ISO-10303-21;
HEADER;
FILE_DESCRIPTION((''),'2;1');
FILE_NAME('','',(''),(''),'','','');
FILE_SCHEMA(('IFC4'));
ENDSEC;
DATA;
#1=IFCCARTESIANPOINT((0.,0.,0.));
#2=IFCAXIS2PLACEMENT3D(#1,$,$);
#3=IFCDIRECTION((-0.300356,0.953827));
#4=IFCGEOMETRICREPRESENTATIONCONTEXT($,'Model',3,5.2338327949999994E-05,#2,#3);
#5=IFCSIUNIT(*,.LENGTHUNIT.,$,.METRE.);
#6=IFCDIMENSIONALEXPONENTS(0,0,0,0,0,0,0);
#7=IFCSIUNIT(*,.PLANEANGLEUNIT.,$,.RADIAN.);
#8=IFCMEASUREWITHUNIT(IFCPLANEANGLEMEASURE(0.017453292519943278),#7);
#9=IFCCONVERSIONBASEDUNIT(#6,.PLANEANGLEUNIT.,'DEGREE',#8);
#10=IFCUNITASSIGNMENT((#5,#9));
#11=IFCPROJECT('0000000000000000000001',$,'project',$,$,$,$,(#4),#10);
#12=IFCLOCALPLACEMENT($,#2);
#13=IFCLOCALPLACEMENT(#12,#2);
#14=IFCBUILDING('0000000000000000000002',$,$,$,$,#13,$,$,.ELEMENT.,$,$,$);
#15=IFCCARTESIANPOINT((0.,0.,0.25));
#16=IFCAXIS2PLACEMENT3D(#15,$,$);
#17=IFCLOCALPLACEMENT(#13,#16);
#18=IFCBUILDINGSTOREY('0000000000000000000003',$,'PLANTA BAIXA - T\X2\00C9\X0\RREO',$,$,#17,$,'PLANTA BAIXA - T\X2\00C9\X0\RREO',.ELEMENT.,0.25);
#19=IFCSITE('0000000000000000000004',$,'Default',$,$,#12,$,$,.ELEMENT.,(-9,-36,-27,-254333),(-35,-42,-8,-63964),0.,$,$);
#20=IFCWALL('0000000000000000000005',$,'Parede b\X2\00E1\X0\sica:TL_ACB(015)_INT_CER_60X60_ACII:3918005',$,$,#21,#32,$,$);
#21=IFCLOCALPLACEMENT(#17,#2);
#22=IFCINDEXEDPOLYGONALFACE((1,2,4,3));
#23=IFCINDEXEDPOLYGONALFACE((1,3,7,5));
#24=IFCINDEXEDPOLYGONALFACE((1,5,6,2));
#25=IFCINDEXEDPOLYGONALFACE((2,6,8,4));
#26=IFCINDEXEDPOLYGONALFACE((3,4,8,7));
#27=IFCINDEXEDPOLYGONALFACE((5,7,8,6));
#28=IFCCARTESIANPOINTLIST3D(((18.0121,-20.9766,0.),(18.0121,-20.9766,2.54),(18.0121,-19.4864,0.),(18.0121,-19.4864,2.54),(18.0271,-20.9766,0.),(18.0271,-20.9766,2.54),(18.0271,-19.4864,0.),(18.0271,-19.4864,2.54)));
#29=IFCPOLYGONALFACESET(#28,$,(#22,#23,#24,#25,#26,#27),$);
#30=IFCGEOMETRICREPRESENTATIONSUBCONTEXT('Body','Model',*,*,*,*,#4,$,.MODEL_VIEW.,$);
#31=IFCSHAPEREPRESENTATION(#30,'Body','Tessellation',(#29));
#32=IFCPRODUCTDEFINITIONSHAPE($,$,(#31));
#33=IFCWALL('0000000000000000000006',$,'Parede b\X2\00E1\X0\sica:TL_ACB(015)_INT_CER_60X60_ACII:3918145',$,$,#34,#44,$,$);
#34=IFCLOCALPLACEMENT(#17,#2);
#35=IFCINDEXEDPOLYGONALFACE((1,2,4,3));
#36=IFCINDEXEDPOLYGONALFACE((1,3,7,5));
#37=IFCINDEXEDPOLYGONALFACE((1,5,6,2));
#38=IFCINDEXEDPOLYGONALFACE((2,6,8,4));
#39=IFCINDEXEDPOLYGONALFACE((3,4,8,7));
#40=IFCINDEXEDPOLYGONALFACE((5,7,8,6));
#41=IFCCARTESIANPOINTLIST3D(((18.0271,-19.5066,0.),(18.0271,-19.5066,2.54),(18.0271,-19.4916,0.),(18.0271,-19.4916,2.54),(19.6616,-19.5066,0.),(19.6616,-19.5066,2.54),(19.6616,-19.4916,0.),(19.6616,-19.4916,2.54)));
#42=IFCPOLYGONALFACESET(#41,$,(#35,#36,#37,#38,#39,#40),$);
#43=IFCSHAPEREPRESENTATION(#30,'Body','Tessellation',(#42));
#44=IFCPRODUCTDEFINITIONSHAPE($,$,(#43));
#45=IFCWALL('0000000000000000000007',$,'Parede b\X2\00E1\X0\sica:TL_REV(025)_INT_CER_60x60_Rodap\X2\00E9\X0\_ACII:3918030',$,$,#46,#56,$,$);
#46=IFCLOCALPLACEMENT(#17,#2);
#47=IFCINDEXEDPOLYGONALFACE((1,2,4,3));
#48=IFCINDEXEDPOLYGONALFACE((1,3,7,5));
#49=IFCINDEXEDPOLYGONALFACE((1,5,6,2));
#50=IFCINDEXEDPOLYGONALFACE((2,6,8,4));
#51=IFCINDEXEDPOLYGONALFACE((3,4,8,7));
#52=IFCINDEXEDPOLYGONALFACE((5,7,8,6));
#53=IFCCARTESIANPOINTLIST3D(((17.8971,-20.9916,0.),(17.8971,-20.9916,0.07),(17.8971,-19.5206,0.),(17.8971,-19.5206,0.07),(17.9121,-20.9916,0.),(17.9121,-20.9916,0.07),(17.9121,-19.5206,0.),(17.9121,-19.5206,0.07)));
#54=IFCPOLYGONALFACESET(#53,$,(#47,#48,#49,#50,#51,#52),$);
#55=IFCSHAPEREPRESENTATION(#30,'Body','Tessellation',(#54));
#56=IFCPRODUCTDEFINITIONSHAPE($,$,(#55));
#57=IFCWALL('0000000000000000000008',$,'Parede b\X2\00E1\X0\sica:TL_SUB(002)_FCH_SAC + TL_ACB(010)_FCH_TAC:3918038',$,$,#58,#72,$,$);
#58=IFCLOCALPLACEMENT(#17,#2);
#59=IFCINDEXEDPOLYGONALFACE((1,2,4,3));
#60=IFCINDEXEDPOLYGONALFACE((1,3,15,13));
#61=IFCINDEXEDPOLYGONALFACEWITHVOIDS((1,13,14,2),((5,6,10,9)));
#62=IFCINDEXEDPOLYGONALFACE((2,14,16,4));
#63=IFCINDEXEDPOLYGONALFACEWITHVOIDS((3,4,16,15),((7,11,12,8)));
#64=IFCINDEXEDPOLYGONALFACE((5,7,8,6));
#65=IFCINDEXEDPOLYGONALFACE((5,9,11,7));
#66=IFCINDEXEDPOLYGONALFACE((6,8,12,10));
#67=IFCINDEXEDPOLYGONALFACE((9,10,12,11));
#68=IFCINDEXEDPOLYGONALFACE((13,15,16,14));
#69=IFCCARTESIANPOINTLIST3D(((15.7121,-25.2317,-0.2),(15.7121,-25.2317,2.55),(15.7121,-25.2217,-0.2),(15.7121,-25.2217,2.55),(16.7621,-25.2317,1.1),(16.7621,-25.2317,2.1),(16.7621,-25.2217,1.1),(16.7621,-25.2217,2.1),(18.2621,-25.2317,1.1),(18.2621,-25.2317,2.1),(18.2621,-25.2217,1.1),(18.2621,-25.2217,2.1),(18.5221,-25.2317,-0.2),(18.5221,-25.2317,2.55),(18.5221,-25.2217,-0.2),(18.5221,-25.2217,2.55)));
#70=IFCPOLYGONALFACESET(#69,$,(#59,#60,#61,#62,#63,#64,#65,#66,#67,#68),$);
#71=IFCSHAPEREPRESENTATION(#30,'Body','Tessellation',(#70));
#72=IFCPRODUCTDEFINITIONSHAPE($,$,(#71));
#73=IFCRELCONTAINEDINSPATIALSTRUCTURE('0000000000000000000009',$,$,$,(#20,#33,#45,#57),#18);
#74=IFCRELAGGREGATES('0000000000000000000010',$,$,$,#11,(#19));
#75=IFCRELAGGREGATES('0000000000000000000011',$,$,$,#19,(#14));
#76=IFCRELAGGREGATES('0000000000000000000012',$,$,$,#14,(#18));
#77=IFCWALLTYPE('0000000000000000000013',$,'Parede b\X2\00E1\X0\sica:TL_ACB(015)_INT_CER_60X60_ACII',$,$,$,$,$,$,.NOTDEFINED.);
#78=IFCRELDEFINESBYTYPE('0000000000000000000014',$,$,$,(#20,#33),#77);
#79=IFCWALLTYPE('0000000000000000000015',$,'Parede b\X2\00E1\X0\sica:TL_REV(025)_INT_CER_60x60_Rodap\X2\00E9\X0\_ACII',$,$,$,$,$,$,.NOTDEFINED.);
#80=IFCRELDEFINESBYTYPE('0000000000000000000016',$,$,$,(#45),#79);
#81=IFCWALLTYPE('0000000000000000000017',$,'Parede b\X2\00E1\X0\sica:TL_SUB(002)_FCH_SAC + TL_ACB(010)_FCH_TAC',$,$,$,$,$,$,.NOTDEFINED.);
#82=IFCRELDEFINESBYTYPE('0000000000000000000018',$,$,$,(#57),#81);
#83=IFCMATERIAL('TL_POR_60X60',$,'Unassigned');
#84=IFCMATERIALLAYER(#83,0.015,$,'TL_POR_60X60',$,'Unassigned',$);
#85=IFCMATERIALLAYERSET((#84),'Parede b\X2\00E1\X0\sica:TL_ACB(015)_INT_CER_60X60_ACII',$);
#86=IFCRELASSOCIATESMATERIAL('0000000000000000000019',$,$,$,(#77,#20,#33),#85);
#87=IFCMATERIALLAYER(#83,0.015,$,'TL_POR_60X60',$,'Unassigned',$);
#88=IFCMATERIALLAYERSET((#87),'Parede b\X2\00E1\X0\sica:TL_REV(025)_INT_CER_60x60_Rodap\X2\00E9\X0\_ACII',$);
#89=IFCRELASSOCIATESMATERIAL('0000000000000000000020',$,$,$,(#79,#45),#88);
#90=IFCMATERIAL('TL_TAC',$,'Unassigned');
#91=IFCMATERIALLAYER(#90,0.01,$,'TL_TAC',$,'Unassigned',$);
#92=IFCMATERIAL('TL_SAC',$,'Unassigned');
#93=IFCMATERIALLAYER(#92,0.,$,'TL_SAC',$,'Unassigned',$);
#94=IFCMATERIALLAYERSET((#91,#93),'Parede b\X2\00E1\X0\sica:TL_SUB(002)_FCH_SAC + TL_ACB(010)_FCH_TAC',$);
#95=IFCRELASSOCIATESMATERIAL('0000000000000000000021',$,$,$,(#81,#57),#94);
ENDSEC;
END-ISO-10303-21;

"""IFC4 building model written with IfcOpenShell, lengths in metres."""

from ifc_helpers import new_model, entity, si_unit, converted_unit, direction, frame, frame_2d, origin, place, context, subcontext, project, spatial, rectangle, extrude, material, layer, layer_set, layer_usage, type_object, element, save


model = new_model("IFC4")

# Units and contexts
model_context = context("Model", 3, precision=5.2338327949999994e-05, world=origin(), true_north=direction((-0.300356, 0.953827)))
body_context = subcontext(model_context, "Body", "Model", "MODEL_VIEW")
ifc_project = project(units=[si_unit("LENGTHUNIT", "METRE"), converted_unit("PLANEANGLEUNIT", "DEGREE", entity("IfcPlaneAngleMeasure", 0.017453292519943278), si_unit("PLANEANGLEUNIT", "RADIAN"), dimensions=[0, 0, 0, 0, 0, 0, 0])], contexts=[model_context])

# Site, building, storey
site_placement = place(None, origin())
site = spatial("IfcSite", under=ifc_project, at=site_placement, Name="Default", CompositionType="ELEMENT", RefLatitude=(-9, -36, -27, -254333), RefLongitude=(-35, -42, -8, -63964), RefElevation=0.0)
building_placement = place(site_placement, origin())
building = spatial("IfcBuilding", under=site, at=building_placement, CompositionType="ELEMENT")
storey_placement = place(building_placement, frame((0.0, 0.0, 0.25)))
storey = spatial("IfcBuildingStorey", under=building, at=storey_placement, Name="PLANTA BAIXA - TÉRREO", LongName="PLANTA BAIXA - TÉRREO", CompositionType="ELEMENT", Elevation=0.25)

# Shared definitions
ifc_material_1 = material(Name="TL_SAC", Category="Unassigned")

# Walls
ifc_material_2 = material(Name="TL_POR_60X60", Category="Unassigned")
ifc_layer_1 = layer(ifc_material_2, 0.015, Name="TL_POR_60X60", Category="Unassigned")
ifc_layer_set_1 = layer_set([ifc_layer_1], Name="Parede básica:TL_ACB(015)_INT_CER_60X60_ACII")
ifc_layer_usage_1 = layer_usage(ifc_layer_set_1, "AXIS2", "NEGATIVE", 0.0075)
wall_type_1 = type_object("IfcWallType", Name="Parede básica:TL_ACB(015)_INT_CER_60X60_ACII", PredefinedType="NOTDEFINED", material=ifc_layer_set_1)
wall_1_placement = place(storey_placement, frame((18.0196, -19.4864, 0.0), z_axis=(0.0, 0.0, 1.0), x_axis=(0.0, -1.0, 0.0)))
element("IfcWall", 1, at=wall_1_placement, inside=storey, type_object=wall_type_1, material=ifc_layer_usage_1, Name="Parede básica:TL_ACB(015)_INT_CER_60X60_ACII:3918005", context=body_context, shape_type="SweptSolid", body=[
    extrude(rectangle(XDim=1.4902, YDim=0.015, at=frame_2d((0.7451, 0.0), x_axis=(-1.0, 0.0))), origin(), (0.0, 0.0, 1.0), 2.54),
])
ifc_layer_usage_2 = layer_usage(ifc_layer_set_1, "AXIS2", "POSITIVE", -0.0075)
wall_2_placement = place(storey_placement, frame((18.0271, -19.4991, 0.0)))
element("IfcWall", 2, at=wall_2_placement, inside=storey, type_object=wall_type_1, material=ifc_layer_usage_2, Name="Parede básica:TL_ACB(015)_INT_CER_60X60_ACII:3918145", context=body_context, shape_type="SweptSolid", body=[
    extrude(rectangle(XDim=1.6345, YDim=0.015, at=frame_2d((0.8172, 0.0), x_axis=(-1.0, 0.0))), origin(), (0.0, 0.0, 1.0), 2.54),
])
ifc_layer_2 = layer(ifc_material_2, 0.015, Name="TL_POR_60X60", Category="Unassigned")
ifc_layer_set_2 = layer_set([ifc_layer_2], Name="Parede básica:TL_REV(025)_INT_CER_60x60_Rodapé_ACII")
ifc_layer_usage_3 = layer_usage(ifc_layer_set_2, "AXIS2", "POSITIVE", -0.0075)
wall_type_2 = type_object("IfcWallType", Name="Parede básica:TL_REV(025)_INT_CER_60x60_Rodapé_ACII", PredefinedType="NOTDEFINED", material=ifc_layer_set_2)
wall_3_placement = place(storey_placement, frame((17.9046, -19.5206, 0.0), z_axis=(0.0, 0.0, 1.0), x_axis=(0.0, -1.0, 0.0)))
element("IfcWall", 3, at=wall_3_placement, inside=storey, type_object=wall_type_2, material=ifc_layer_usage_3, Name="Parede básica:TL_REV(025)_INT_CER_60x60_Rodapé_ACII:3918030", context=body_context, shape_type="SweptSolid", body=[
    extrude(rectangle(XDim=1.471, YDim=0.015, at=frame_2d((0.7355, 0.0), x_axis=(-1.0, 0.0))), origin(), (0.0, 0.0, 1.0), 0.07),
])

# Wall, opening
ifc_material_3 = material(Name="TL_TAC", Category="Unassigned")
ifc_layer_3 = layer(ifc_material_3, 0.01, Name="TL_TAC", Category="Unassigned")
ifc_layer_4 = layer(ifc_material_1, 0.0, Name="TL_SAC", Category="Unassigned")
ifc_layer_set_3 = layer_set([ifc_layer_3, ifc_layer_4], Name="Parede básica:TL_SUB(002)_FCH_SAC + TL_ACB(010)_FCH_TAC")
ifc_layer_usage_4 = layer_usage(ifc_layer_set_3, "AXIS2", "POSITIVE", -0.005)
wall_type_3 = type_object("IfcWallType", Name="Parede básica:TL_SUB(002)_FCH_SAC + TL_ACB(010)_FCH_TAC", PredefinedType="NOTDEFINED", material=ifc_layer_set_3)
wall_4_placement = place(storey_placement, frame((15.7121, -25.2267, -0.2)))
wall_4 = element("IfcWall", 4, at=wall_4_placement, inside=storey, type_object=wall_type_3, material=ifc_layer_usage_4, Name="Parede básica:TL_SUB(002)_FCH_SAC + TL_ACB(010)_FCH_TAC:3918038", context=body_context, shape_type="SweptSolid", body=[
    extrude(rectangle(XDim=2.81, YDim=0.01, at=frame_2d((1.405, 0.0), x_axis=(-1.0, 0.0))), origin(), (0.0, 0.0, 1.0), 2.75),
])
opening_1_placement = place(wall_4_placement, frame((-15.7121, 25.2267, 1.3)))
element("IfcOpeningElement", 5, at=opening_1_placement, cuts=wall_4, PredefinedType="OPENING", context=body_context, shape_type="SweptSolid", body=[
    extrude(rectangle(XDim=1.0, YDim=1.5, at=frame_2d((0.0, 0.0), x_axis=(0.0, 1.0))), frame((17.5121, -26.6457, 0.5), z_axis=(0.0, 1.0, 0.0), x_axis=(1.0, 0.0, 0.0)), (0.0, 0.0, 1.0), 3.048),
])

save(model, "model.ifc")
